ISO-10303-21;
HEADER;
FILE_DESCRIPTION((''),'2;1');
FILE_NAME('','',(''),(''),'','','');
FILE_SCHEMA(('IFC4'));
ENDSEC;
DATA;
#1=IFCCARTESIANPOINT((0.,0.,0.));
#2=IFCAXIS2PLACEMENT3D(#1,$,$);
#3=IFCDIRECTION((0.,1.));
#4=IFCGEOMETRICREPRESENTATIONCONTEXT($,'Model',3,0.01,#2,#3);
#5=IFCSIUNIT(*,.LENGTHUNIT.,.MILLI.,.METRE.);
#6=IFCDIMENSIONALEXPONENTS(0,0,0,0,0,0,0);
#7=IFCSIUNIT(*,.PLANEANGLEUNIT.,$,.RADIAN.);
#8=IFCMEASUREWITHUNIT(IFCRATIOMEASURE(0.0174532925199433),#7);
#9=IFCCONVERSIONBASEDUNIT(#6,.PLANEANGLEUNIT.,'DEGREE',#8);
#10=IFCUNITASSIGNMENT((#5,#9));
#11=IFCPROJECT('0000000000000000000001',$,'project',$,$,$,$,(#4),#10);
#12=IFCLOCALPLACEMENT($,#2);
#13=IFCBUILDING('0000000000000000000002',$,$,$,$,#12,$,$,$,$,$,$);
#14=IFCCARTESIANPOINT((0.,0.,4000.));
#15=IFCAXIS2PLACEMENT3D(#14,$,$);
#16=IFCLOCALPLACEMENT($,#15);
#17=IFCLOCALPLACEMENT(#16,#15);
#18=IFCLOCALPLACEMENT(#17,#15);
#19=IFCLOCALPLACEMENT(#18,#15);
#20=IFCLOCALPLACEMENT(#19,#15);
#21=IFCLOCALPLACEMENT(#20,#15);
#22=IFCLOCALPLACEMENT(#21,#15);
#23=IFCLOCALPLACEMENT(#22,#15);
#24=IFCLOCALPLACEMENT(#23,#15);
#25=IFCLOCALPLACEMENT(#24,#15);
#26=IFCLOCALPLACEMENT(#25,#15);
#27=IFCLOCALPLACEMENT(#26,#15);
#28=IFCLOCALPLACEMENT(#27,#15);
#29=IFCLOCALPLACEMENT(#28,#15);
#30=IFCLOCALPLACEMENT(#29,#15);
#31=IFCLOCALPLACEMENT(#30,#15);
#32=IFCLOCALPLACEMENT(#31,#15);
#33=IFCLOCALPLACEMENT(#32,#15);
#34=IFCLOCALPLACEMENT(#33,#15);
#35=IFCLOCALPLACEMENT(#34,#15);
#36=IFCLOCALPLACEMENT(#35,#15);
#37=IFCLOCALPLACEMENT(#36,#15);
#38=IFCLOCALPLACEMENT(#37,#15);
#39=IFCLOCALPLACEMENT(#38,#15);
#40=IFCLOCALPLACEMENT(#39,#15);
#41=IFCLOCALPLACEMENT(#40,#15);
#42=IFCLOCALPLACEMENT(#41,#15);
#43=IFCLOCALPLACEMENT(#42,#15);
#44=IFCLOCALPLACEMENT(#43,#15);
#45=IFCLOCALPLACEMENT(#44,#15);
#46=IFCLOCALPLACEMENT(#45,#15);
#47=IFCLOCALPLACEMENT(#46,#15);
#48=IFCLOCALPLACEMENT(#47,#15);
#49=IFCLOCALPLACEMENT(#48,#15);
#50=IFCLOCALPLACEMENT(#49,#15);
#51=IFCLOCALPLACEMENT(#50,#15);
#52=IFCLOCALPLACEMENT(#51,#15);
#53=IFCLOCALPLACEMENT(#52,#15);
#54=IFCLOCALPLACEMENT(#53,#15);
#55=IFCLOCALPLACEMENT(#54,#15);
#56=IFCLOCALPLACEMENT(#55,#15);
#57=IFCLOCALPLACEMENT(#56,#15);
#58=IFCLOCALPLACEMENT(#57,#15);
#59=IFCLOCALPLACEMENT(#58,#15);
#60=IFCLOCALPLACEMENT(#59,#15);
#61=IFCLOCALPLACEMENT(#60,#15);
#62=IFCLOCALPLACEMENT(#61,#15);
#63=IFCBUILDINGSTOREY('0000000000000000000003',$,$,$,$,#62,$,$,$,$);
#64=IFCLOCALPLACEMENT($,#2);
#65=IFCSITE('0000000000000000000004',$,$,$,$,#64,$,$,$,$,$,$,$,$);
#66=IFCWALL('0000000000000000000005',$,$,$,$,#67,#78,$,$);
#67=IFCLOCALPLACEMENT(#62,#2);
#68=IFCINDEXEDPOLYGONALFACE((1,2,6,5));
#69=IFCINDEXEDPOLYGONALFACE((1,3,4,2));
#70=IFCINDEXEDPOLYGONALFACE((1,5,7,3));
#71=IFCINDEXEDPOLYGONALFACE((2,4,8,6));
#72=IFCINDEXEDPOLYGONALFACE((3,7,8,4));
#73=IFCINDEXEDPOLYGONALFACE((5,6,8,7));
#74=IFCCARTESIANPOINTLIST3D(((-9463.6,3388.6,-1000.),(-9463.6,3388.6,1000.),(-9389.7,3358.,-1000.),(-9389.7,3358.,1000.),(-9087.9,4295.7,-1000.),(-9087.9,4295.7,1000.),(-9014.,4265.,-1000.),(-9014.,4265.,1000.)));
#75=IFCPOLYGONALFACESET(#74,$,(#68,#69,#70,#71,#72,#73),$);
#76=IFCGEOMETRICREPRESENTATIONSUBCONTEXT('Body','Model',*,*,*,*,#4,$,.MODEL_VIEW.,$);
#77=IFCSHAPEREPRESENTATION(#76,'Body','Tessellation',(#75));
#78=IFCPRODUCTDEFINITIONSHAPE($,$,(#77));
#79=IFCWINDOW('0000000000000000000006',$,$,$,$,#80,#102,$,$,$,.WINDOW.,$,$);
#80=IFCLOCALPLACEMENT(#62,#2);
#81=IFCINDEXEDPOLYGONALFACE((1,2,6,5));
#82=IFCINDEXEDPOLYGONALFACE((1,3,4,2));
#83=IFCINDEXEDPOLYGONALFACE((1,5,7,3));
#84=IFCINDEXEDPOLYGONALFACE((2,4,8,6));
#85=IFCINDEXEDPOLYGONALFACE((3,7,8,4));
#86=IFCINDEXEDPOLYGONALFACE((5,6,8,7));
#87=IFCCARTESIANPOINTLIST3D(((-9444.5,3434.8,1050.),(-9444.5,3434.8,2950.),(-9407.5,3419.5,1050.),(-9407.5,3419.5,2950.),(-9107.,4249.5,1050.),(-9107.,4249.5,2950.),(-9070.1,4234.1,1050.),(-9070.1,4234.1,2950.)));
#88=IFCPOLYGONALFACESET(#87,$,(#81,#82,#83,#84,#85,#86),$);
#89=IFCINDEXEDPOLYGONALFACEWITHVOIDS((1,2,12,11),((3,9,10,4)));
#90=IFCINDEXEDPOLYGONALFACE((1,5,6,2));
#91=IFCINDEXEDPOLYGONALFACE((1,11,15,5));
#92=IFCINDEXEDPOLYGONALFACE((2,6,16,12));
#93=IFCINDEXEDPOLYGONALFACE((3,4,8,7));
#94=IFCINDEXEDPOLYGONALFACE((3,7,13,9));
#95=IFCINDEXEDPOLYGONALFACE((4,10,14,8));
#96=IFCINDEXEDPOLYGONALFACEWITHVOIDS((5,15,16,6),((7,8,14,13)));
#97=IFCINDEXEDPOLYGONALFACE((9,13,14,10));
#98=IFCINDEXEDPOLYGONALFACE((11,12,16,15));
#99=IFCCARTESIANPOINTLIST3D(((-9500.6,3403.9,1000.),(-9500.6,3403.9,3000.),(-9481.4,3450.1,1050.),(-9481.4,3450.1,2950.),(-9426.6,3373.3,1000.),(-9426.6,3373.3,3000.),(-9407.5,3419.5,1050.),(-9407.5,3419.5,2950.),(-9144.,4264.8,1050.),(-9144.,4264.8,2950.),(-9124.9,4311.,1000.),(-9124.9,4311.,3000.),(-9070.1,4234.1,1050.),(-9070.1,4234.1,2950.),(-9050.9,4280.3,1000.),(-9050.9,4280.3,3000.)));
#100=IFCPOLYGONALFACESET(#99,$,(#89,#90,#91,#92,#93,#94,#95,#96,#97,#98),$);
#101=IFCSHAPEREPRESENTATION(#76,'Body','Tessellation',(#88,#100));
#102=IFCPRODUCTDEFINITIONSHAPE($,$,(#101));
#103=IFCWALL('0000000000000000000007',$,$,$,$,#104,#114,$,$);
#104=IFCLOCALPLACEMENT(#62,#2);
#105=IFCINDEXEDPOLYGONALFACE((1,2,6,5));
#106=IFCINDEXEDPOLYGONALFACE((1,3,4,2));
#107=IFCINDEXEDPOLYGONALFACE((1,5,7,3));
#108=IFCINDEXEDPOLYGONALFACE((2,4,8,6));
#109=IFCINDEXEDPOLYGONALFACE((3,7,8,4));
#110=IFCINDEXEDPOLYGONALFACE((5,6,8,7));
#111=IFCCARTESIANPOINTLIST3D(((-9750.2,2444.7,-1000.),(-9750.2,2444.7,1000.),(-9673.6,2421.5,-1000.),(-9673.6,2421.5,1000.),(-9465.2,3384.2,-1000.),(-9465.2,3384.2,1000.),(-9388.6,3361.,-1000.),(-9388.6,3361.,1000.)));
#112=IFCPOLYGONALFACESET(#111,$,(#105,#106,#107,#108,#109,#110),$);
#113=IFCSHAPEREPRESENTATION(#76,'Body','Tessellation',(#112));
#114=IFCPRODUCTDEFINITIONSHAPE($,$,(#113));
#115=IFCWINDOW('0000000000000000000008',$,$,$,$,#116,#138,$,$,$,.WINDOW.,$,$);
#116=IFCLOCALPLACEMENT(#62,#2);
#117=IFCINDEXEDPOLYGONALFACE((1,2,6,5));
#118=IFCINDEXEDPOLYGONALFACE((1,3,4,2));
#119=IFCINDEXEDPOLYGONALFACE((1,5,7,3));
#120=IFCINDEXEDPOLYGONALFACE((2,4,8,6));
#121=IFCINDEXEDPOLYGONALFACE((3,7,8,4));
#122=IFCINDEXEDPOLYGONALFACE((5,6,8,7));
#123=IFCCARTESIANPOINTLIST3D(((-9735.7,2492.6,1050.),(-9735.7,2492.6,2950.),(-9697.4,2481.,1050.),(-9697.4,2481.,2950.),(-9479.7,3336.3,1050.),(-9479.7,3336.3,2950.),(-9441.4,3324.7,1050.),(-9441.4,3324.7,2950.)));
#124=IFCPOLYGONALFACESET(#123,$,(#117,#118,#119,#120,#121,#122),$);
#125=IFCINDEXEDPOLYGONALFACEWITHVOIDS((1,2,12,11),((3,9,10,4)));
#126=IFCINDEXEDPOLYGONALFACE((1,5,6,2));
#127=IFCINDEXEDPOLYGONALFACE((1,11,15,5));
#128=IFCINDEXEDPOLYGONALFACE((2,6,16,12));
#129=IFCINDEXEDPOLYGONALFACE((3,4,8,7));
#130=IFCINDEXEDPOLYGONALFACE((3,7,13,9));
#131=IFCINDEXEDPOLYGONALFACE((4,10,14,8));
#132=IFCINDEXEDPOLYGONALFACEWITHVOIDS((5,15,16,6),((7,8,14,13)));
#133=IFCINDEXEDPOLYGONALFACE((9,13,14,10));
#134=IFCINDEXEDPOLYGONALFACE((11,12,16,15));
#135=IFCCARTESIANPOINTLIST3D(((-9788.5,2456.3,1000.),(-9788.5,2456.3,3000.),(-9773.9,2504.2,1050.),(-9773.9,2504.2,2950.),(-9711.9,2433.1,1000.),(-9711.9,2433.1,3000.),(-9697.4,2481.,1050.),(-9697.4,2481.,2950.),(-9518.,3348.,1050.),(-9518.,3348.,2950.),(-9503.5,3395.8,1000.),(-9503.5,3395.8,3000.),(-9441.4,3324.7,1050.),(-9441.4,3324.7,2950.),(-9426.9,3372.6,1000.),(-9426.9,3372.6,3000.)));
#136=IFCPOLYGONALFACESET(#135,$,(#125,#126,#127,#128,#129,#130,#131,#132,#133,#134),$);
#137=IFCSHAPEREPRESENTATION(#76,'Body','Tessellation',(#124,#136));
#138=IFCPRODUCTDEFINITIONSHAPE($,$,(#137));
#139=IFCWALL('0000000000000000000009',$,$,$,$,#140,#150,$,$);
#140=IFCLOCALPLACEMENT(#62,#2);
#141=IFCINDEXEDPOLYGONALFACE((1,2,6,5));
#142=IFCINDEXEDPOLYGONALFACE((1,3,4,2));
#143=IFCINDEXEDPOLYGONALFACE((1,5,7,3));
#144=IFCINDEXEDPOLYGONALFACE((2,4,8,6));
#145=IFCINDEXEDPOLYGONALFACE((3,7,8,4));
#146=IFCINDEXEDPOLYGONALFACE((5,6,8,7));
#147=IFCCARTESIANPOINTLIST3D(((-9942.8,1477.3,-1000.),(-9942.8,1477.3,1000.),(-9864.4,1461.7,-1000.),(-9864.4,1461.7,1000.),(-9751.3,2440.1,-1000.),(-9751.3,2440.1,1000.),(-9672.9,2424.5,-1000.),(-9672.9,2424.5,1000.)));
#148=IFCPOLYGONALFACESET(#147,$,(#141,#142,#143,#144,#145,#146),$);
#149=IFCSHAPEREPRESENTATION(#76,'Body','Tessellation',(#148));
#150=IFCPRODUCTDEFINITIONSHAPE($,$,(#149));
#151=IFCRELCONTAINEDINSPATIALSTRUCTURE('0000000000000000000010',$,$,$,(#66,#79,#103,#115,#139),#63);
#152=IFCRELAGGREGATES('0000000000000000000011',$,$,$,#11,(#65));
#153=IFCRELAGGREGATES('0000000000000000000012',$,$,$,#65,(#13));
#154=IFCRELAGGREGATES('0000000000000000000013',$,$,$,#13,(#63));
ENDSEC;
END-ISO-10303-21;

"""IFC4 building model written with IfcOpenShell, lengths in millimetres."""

from ifc_helpers import new_model, entity, si_unit, converted_unit, direction, frame, origin, origin_2d, place, context, subcontext, project, spatial, rectangle, extrude, element, save


model = new_model("IFC4")

# Units and contexts
model_context = context("Model", 3, precision=0.01, world=origin(), true_north=direction((0.0, 1.0)))
body_context = subcontext(model_context, "Body", "Model", "MODEL_VIEW")
ifc_project = project(units=[si_unit("LENGTHUNIT", "METRE", prefix="MILLI"), converted_unit("PLANEANGLEUNIT", "DEGREE", entity("IfcRatioMeasure", 0.0174532925199433), si_unit("PLANEANGLEUNIT", "RADIAN"), dimensions=[0, 0, 0, 0, 0, 0, 0])], contexts=[model_context])

# Site, building, storey
site_placement = place(None, origin())
site = spatial("IfcSite", under=ifc_project, at=site_placement)
building_placement = place(None, origin())
building = spatial("IfcBuilding", under=site, at=building_placement)
placement_1 = place(None, frame((0.0, 0.0, 4000.0)))
placement_2 = place(placement_1, frame((0.0, 0.0, 4000.0)))
placement_3 = place(placement_2, frame((0.0, 0.0, 4000.0)))
placement_4 = place(placement_3, frame((0.0, 0.0, 4000.0)))
placement_5 = place(placement_4, frame((0.0, 0.0, 4000.0)))
placement_6 = place(placement_5, frame((0.0, 0.0, 4000.0)))
placement_7 = place(placement_6, frame((0.0, 0.0, 4000.0)))
placement_8 = place(placement_7, frame((0.0, 0.0, 4000.0)))
placement_9 = place(placement_8, frame((0.0, 0.0, 4000.0)))
placement_10 = place(placement_9, frame((0.0, 0.0, 4000.0)))
placement_11 = place(placement_10, frame((0.0, 0.0, 4000.0)))
placement_12 = place(placement_11, frame((0.0, 0.0, 4000.0)))
placement_13 = place(placement_12, frame((0.0, 0.0, 4000.0)))
placement_14 = place(placement_13, frame((0.0, 0.0, 4000.0)))
placement_15 = place(placement_14, frame((0.0, 0.0, 4000.0)))
placement_16 = place(placement_15, frame((0.0, 0.0, 4000.0)))
placement_17 = place(placement_16, frame((0.0, 0.0, 4000.0)))
placement_18 = place(placement_17, frame((0.0, 0.0, 4000.0)))
placement_19 = place(placement_18, frame((0.0, 0.0, 4000.0)))
placement_20 = place(placement_19, frame((0.0, 0.0, 4000.0)))
placement_21 = place(placement_20, frame((0.0, 0.0, 4000.0)))
placement_22 = place(placement_21, frame((0.0, 0.0, 4000.0)))
placement_23 = place(placement_22, frame((0.0, 0.0, 4000.0)))
placement_24 = place(placement_23, frame((0.0, 0.0, 4000.0)))
placement_25 = place(placement_24, frame((0.0, 0.0, 4000.0)))
placement_26 = place(placement_25, frame((0.0, 0.0, 4000.0)))
placement_27 = place(placement_26, frame((0.0, 0.0, 4000.0)))
placement_28 = place(placement_27, frame((0.0, 0.0, 4000.0)))
placement_29 = place(placement_28, frame((0.0, 0.0, 4000.0)))
placement_30 = place(placement_29, frame((0.0, 0.0, 4000.0)))
placement_31 = place(placement_30, frame((0.0, 0.0, 4000.0)))
placement_32 = place(placement_31, frame((0.0, 0.0, 4000.0)))
placement_33 = place(placement_32, frame((0.0, 0.0, 4000.0)))
placement_34 = place(placement_33, frame((0.0, 0.0, 4000.0)))
placement_35 = place(placement_34, frame((0.0, 0.0, 4000.0)))
placement_36 = place(placement_35, frame((0.0, 0.0, 4000.0)))
placement_37 = place(placement_36, frame((0.0, 0.0, 4000.0)))
placement_38 = place(placement_37, frame((0.0, 0.0, 4000.0)))
placement_39 = place(placement_38, frame((0.0, 0.0, 4000.0)))
placement_40 = place(placement_39, frame((0.0, 0.0, 4000.0)))
placement_41 = place(placement_40, frame((0.0, 0.0, 4000.0)))
placement_42 = place(placement_41, frame((0.0, 0.0, 4000.0)))
placement_43 = place(placement_42, frame((0.0, 0.0, 4000.0)))
placement_44 = place(placement_43, frame((0.0, 0.0, 4000.0)))
placement_45 = place(placement_44, frame((0.0, 0.0, 4000.0)))
placement_46 = place(placement_45, frame((0.0, 0.0, 4000.0)))
storey_placement = place(placement_46, frame((0.0, 0.0, 4000.0)))
storey = spatial("IfcBuildingStorey", under=building, at=storey_placement)

# Shared definitions
cartesian_point_1 = entity("IfcCartesianPoint", [-440.9, -950.0])
shared_polyline = entity("IfcPolyline", [cartesian_point_1, entity("IfcCartesianPoint", [-440.9, 950.0]), entity("IfcCartesianPoint", [-440.9, 950.0]), entity("IfcCartesianPoint", [440.9, 950.0]), entity("IfcCartesianPoint", [440.9, 950.0]), entity("IfcCartesianPoint", [440.9, -950.0]), entity("IfcCartesianPoint", [440.9, -950.0]), entity("IfcCartesianPoint", [-440.9, -950.0]), cartesian_point_1])

# Wall
wall_1_placement = place(storey_placement, frame((-9238.8, 3826.8, -1000.0), z_axis=(0.0, 0.0, 1.0), x_axis=(-3826.834994, -9238.795048, 0.0)))
element("IfcWall", 1, at=wall_1_placement, inside=storey, context=body_context, shape_type="SweptSolid", body=[
    extrude(rectangle(XDim=981.7, YDim=80.0, at=origin_2d()), origin(), (0.0, 0.0, 1.0), 2000.0),
])

# Window
window_1_placement = place(storey_placement, frame((-9238.8, 3826.8, 2000.0), z_axis=(0.0, 0.0, 1.0), x_axis=(-3826.834994, -9238.795048, 0.0)))
cartesian_point_2 = entity("IfcCartesianPoint", [-490.9, -1000.0])
element("IfcWindow", 2, at=window_1_placement, inside=storey, PredefinedType="WINDOW", context=body_context, shape_type="SweptSolid", body=[
    entity("IfcExtrudedAreaSolid", entity("IfcArbitraryClosedProfileDef", "AREA", None, shared_polyline), entity("IfcAxis2Placement3D", entity("IfcCartesianPoint", [0.0, 0.0, 0.0]), entity("IfcDirection", [0.0, -1.0, 0.0]), entity("IfcDirection", [1.0, 0.0, 0.0])), entity("IfcDirection", [0.0, 0.0, 1.0]), 40.0),
    entity("IfcExtrudedAreaSolid", entity("IfcArbitraryProfileDefWithVoids", "AREA", None, entity("IfcPolyline", [cartesian_point_2, entity("IfcCartesianPoint", [-490.9, 1000.0]), entity("IfcCartesianPoint", [-490.9, 1000.0]), entity("IfcCartesianPoint", [490.9, 1000.0]), entity("IfcCartesianPoint", [490.9, 1000.0]), entity("IfcCartesianPoint", [490.9, -1000.0]), entity("IfcCartesianPoint", [490.9, -1000.0]), entity("IfcCartesianPoint", [-490.9, -1000.0]), cartesian_point_2]), [shared_polyline]), entity("IfcAxis2Placement3D", entity("IfcCartesianPoint", [0.0, 0.0, 0.0]), entity("IfcDirection", [0.0, -1.0, 0.0]), entity("IfcDirection", [1.0, 0.0, 0.0])), entity("IfcDirection", [0.0, 0.0, 1.0]), 80.0),
])

# Wall
wall_2_placement = place(storey_placement, frame((-9569.4, 2902.8, -1000.0), z_axis=(0.0, 0.0, 1.0), x_axis=(-2902.847084, -9569.403263, 0.0)))
element("IfcWall", 3, at=wall_2_placement, inside=storey, context=body_context, shape_type="SweptSolid", body=[
    extrude(rectangle(XDim=981.7, YDim=80.0, at=origin_2d()), origin(), (0.0, 0.0, 1.0), 2000.0),
])

# Window
window_2_placement = place(storey_placement, frame((-9569.4, 2902.8, 2000.0), z_axis=(0.0, 0.0, 1.0), x_axis=(-2902.847084, -9569.403263, 0.0)))
cartesian_point_3 = entity("IfcCartesianPoint", [-490.9, -1000.0])
element("IfcWindow", 4, at=window_2_placement, inside=storey, PredefinedType="WINDOW", context=body_context, shape_type="SweptSolid", body=[
    entity("IfcExtrudedAreaSolid", entity("IfcArbitraryClosedProfileDef", "AREA", None, shared_polyline), entity("IfcAxis2Placement3D", entity("IfcCartesianPoint", [0.0, 0.0, 0.0]), entity("IfcDirection", [0.0, -1.0, 0.0]), entity("IfcDirection", [1.0, 0.0, 0.0])), entity("IfcDirection", [0.0, 0.0, 1.0]), 40.0),
    entity("IfcExtrudedAreaSolid", entity("IfcArbitraryProfileDefWithVoids", "AREA", None, entity("IfcPolyline", [cartesian_point_3, entity("IfcCartesianPoint", [-490.9, 1000.0]), entity("IfcCartesianPoint", [-490.9, 1000.0]), entity("IfcCartesianPoint", [490.9, 1000.0]), entity("IfcCartesianPoint", [490.9, 1000.0]), entity("IfcCartesianPoint", [490.9, -1000.0]), entity("IfcCartesianPoint", [490.9, -1000.0]), entity("IfcCartesianPoint", [-490.9, -1000.0]), cartesian_point_3]), [shared_polyline]), entity("IfcAxis2Placement3D", entity("IfcCartesianPoint", [0.0, 0.0, 0.0]), entity("IfcDirection", [0.0, -1.0, 0.0]), entity("IfcDirection", [1.0, 0.0, 0.0])), entity("IfcDirection", [0.0, 0.0, 1.0]), 80.0),
])

# Wall
wall_3_placement = place(storey_placement, frame((-9807.9, 1950.9, -1000.0), z_axis=(0.0, 0.0, 1.0), x_axis=(-1950.903147, -9807.852819, 0.0)))
element("IfcWall", 5, at=wall_3_placement, inside=storey, context=body_context, shape_type="SweptSolid", body=[
    extrude(rectangle(XDim=981.7, YDim=80.0, at=origin_2d()), origin(), (0.0, 0.0, 1.0), 2000.0),
])

save(model, "model.ifc")
